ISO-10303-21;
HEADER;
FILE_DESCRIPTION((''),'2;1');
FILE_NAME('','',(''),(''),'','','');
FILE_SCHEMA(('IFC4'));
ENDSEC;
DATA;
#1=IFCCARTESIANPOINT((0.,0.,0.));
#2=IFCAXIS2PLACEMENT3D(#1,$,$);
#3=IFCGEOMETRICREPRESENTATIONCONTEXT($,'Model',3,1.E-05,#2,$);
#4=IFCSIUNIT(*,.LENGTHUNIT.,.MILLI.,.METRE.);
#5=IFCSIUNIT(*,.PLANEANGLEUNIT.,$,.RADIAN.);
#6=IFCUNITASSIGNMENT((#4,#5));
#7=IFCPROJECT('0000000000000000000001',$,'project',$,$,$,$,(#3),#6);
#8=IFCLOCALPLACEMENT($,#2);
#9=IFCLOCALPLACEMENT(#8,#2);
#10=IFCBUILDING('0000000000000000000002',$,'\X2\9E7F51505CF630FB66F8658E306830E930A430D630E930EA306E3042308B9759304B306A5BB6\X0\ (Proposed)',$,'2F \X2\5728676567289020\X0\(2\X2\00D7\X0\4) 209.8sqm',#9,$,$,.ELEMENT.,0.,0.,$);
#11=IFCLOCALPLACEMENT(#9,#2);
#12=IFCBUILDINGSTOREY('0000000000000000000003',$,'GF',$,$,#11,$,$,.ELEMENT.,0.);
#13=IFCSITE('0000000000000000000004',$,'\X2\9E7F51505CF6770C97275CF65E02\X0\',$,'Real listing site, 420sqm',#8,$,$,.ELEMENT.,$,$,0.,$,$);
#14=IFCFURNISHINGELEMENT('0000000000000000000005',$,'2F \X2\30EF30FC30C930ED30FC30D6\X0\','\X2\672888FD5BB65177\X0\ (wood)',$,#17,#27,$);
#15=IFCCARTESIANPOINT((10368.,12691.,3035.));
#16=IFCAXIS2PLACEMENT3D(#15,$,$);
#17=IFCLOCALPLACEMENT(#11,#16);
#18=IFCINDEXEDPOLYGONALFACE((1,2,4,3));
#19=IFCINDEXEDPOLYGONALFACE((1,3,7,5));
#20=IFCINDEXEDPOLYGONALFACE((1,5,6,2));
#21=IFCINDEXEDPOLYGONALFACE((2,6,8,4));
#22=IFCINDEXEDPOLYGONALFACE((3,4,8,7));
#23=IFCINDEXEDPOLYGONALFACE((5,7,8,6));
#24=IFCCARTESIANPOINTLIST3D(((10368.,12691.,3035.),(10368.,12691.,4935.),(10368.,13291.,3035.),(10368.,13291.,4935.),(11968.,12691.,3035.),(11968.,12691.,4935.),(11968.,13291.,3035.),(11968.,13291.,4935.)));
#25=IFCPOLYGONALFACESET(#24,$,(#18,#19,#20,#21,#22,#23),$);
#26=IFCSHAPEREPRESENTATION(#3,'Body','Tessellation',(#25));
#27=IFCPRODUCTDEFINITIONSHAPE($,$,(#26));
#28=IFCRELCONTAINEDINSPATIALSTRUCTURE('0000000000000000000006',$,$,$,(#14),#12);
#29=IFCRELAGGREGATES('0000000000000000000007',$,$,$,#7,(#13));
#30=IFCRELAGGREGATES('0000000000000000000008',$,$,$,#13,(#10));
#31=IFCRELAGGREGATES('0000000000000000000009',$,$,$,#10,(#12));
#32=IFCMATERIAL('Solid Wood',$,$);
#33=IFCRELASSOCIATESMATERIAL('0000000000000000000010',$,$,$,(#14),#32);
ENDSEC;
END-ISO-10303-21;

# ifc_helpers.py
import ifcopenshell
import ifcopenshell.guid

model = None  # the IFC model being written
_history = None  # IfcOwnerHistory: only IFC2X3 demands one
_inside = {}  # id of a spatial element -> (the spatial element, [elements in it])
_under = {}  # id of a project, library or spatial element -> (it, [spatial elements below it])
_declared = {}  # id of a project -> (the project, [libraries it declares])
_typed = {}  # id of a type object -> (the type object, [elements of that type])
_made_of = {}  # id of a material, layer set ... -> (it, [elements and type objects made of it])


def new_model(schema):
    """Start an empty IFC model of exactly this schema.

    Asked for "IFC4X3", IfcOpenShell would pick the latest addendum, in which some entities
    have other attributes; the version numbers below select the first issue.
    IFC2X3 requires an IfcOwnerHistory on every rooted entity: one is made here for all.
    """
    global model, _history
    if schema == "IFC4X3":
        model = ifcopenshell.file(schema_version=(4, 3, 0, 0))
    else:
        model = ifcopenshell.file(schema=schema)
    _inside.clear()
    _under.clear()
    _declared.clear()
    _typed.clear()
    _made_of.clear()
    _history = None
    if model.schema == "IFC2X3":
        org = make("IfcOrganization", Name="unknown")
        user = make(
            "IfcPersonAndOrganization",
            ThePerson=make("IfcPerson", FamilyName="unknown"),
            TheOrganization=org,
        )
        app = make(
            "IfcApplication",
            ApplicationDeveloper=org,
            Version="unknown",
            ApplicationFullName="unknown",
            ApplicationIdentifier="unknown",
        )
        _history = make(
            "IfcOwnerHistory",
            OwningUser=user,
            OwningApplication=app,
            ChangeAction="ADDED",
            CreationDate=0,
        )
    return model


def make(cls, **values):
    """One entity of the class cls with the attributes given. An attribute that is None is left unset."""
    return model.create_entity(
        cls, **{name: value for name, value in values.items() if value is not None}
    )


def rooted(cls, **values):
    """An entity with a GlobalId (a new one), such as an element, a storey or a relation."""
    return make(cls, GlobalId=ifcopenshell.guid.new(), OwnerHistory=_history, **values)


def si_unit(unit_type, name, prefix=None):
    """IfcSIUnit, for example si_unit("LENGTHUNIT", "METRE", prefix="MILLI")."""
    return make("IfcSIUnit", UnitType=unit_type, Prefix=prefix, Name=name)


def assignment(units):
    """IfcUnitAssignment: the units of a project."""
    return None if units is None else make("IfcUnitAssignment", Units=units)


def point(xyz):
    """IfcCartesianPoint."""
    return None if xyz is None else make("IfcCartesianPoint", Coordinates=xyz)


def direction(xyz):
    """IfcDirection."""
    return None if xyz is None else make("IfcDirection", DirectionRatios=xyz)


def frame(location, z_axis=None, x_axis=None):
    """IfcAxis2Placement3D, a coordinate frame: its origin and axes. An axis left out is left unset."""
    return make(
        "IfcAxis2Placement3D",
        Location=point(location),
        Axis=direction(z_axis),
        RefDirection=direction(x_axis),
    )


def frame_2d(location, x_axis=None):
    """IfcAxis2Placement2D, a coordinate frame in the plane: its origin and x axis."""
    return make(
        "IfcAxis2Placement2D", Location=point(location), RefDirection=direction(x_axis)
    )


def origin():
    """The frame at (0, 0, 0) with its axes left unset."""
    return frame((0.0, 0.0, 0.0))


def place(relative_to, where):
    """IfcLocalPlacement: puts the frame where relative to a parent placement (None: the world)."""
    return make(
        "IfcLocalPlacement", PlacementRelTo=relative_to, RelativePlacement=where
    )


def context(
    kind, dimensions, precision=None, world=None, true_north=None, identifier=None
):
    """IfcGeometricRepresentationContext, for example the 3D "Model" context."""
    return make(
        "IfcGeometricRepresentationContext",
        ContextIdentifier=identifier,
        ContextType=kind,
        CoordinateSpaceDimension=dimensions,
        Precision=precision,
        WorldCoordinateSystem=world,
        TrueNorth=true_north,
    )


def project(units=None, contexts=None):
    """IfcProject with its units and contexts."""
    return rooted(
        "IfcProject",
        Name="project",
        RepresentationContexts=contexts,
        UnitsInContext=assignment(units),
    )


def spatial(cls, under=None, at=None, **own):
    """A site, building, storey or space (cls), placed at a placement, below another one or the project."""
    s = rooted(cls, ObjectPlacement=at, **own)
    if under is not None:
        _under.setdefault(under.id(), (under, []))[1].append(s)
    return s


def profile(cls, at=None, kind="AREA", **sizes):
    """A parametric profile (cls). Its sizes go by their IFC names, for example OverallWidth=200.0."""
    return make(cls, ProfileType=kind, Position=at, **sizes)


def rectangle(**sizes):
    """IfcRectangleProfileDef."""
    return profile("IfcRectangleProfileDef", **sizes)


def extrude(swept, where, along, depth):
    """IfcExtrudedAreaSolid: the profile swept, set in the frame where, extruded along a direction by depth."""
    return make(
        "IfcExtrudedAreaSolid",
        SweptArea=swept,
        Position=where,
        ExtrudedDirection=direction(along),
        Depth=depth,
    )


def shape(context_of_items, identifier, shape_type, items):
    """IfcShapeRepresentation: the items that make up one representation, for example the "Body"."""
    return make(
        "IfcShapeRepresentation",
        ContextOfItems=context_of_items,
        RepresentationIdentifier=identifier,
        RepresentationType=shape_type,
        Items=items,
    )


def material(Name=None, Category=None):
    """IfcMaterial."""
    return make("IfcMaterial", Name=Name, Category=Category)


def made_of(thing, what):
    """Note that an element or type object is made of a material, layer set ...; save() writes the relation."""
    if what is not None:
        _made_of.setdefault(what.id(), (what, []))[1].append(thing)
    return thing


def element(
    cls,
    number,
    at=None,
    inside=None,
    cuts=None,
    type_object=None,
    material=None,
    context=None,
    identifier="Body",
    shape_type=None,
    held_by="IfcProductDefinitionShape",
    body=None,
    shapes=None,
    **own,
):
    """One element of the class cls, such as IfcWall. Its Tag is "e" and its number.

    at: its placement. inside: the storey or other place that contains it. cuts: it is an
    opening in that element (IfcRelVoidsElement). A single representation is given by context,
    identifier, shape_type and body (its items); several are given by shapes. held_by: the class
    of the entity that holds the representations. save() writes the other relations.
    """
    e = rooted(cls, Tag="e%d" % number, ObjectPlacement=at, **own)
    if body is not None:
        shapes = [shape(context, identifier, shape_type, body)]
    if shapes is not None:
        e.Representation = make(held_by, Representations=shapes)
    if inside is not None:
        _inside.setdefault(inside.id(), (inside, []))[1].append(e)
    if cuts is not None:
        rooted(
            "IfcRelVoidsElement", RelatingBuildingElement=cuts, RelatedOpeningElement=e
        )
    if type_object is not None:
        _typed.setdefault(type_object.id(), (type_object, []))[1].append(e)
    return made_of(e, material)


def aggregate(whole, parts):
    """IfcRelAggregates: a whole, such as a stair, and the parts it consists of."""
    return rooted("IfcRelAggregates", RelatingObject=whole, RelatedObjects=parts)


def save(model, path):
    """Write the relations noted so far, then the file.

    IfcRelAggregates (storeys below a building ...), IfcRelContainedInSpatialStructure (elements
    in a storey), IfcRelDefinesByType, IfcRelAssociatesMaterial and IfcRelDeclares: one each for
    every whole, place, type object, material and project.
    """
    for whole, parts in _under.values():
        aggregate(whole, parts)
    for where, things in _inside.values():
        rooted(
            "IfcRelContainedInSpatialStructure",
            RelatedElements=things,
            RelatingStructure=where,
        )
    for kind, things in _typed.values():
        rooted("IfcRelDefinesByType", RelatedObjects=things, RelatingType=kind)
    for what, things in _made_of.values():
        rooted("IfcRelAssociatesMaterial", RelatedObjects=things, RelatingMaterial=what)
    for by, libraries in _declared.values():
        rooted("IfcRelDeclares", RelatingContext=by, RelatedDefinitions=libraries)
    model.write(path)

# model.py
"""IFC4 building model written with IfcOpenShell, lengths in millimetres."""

from ifc_helpers import new_model, si_unit, frame, frame_2d, origin, place, context, project, spatial, rectangle, extrude, material, element, save


model = new_model("IFC4")

# Units and contexts
model_context = context("Model", 3, precision=1e-05, world=origin())
ifc_project = project(units=[si_unit("LENGTHUNIT", "METRE", prefix="MILLI"), si_unit("PLANEANGLEUNIT", "RADIAN")], contexts=[model_context])

# Site, building, storey
site_placement = place(None, origin())
site = spatial("IfcSite", under=ifc_project, at=site_placement, Name="鹿児島県霧島市", ObjectType="Real listing site, 420sqm", CompositionType="ELEMENT", RefElevation=0.0)
building_placement = place(site_placement, origin())
building = spatial("IfcBuilding", under=site, at=building_placement, Name="鹿児島・書斎とライブラリのある静かな家 (Proposed)", ObjectType="2F 在来木造(2×4) 209.8sqm", CompositionType="ELEMENT", ElevationOfRefHeight=0.0, ElevationOfTerrain=0.0)
storey_placement = place(building_placement, origin())
storey = spatial("IfcBuildingStorey", under=building, at=storey_placement, Name="GF", CompositionType="ELEMENT", Elevation=0.0)

# Shared definitions
ifc_material_1 = material(Name="Solid Wood")

# Furnishing element
furnishing_1_placement = place(storey_placement, frame((10368.0, 12691.0, 3035.0)))
element("IfcFurnishingElement", 1, at=furnishing_1_placement, inside=storey, material=ifc_material_1, Name="2F ワードローブ", Description="木製家具 (wood)", context=model_context, shape_type="SweptSolid", body=[
    extrude(rectangle(XDim=1600.0, YDim=600.0, at=frame_2d((800.0, 300.0))), frame((10368.0, 12691.0, 3035.0)), (0.0, 0.0, 1.0), 1900.0),
])

save(model, "model.ifc")
